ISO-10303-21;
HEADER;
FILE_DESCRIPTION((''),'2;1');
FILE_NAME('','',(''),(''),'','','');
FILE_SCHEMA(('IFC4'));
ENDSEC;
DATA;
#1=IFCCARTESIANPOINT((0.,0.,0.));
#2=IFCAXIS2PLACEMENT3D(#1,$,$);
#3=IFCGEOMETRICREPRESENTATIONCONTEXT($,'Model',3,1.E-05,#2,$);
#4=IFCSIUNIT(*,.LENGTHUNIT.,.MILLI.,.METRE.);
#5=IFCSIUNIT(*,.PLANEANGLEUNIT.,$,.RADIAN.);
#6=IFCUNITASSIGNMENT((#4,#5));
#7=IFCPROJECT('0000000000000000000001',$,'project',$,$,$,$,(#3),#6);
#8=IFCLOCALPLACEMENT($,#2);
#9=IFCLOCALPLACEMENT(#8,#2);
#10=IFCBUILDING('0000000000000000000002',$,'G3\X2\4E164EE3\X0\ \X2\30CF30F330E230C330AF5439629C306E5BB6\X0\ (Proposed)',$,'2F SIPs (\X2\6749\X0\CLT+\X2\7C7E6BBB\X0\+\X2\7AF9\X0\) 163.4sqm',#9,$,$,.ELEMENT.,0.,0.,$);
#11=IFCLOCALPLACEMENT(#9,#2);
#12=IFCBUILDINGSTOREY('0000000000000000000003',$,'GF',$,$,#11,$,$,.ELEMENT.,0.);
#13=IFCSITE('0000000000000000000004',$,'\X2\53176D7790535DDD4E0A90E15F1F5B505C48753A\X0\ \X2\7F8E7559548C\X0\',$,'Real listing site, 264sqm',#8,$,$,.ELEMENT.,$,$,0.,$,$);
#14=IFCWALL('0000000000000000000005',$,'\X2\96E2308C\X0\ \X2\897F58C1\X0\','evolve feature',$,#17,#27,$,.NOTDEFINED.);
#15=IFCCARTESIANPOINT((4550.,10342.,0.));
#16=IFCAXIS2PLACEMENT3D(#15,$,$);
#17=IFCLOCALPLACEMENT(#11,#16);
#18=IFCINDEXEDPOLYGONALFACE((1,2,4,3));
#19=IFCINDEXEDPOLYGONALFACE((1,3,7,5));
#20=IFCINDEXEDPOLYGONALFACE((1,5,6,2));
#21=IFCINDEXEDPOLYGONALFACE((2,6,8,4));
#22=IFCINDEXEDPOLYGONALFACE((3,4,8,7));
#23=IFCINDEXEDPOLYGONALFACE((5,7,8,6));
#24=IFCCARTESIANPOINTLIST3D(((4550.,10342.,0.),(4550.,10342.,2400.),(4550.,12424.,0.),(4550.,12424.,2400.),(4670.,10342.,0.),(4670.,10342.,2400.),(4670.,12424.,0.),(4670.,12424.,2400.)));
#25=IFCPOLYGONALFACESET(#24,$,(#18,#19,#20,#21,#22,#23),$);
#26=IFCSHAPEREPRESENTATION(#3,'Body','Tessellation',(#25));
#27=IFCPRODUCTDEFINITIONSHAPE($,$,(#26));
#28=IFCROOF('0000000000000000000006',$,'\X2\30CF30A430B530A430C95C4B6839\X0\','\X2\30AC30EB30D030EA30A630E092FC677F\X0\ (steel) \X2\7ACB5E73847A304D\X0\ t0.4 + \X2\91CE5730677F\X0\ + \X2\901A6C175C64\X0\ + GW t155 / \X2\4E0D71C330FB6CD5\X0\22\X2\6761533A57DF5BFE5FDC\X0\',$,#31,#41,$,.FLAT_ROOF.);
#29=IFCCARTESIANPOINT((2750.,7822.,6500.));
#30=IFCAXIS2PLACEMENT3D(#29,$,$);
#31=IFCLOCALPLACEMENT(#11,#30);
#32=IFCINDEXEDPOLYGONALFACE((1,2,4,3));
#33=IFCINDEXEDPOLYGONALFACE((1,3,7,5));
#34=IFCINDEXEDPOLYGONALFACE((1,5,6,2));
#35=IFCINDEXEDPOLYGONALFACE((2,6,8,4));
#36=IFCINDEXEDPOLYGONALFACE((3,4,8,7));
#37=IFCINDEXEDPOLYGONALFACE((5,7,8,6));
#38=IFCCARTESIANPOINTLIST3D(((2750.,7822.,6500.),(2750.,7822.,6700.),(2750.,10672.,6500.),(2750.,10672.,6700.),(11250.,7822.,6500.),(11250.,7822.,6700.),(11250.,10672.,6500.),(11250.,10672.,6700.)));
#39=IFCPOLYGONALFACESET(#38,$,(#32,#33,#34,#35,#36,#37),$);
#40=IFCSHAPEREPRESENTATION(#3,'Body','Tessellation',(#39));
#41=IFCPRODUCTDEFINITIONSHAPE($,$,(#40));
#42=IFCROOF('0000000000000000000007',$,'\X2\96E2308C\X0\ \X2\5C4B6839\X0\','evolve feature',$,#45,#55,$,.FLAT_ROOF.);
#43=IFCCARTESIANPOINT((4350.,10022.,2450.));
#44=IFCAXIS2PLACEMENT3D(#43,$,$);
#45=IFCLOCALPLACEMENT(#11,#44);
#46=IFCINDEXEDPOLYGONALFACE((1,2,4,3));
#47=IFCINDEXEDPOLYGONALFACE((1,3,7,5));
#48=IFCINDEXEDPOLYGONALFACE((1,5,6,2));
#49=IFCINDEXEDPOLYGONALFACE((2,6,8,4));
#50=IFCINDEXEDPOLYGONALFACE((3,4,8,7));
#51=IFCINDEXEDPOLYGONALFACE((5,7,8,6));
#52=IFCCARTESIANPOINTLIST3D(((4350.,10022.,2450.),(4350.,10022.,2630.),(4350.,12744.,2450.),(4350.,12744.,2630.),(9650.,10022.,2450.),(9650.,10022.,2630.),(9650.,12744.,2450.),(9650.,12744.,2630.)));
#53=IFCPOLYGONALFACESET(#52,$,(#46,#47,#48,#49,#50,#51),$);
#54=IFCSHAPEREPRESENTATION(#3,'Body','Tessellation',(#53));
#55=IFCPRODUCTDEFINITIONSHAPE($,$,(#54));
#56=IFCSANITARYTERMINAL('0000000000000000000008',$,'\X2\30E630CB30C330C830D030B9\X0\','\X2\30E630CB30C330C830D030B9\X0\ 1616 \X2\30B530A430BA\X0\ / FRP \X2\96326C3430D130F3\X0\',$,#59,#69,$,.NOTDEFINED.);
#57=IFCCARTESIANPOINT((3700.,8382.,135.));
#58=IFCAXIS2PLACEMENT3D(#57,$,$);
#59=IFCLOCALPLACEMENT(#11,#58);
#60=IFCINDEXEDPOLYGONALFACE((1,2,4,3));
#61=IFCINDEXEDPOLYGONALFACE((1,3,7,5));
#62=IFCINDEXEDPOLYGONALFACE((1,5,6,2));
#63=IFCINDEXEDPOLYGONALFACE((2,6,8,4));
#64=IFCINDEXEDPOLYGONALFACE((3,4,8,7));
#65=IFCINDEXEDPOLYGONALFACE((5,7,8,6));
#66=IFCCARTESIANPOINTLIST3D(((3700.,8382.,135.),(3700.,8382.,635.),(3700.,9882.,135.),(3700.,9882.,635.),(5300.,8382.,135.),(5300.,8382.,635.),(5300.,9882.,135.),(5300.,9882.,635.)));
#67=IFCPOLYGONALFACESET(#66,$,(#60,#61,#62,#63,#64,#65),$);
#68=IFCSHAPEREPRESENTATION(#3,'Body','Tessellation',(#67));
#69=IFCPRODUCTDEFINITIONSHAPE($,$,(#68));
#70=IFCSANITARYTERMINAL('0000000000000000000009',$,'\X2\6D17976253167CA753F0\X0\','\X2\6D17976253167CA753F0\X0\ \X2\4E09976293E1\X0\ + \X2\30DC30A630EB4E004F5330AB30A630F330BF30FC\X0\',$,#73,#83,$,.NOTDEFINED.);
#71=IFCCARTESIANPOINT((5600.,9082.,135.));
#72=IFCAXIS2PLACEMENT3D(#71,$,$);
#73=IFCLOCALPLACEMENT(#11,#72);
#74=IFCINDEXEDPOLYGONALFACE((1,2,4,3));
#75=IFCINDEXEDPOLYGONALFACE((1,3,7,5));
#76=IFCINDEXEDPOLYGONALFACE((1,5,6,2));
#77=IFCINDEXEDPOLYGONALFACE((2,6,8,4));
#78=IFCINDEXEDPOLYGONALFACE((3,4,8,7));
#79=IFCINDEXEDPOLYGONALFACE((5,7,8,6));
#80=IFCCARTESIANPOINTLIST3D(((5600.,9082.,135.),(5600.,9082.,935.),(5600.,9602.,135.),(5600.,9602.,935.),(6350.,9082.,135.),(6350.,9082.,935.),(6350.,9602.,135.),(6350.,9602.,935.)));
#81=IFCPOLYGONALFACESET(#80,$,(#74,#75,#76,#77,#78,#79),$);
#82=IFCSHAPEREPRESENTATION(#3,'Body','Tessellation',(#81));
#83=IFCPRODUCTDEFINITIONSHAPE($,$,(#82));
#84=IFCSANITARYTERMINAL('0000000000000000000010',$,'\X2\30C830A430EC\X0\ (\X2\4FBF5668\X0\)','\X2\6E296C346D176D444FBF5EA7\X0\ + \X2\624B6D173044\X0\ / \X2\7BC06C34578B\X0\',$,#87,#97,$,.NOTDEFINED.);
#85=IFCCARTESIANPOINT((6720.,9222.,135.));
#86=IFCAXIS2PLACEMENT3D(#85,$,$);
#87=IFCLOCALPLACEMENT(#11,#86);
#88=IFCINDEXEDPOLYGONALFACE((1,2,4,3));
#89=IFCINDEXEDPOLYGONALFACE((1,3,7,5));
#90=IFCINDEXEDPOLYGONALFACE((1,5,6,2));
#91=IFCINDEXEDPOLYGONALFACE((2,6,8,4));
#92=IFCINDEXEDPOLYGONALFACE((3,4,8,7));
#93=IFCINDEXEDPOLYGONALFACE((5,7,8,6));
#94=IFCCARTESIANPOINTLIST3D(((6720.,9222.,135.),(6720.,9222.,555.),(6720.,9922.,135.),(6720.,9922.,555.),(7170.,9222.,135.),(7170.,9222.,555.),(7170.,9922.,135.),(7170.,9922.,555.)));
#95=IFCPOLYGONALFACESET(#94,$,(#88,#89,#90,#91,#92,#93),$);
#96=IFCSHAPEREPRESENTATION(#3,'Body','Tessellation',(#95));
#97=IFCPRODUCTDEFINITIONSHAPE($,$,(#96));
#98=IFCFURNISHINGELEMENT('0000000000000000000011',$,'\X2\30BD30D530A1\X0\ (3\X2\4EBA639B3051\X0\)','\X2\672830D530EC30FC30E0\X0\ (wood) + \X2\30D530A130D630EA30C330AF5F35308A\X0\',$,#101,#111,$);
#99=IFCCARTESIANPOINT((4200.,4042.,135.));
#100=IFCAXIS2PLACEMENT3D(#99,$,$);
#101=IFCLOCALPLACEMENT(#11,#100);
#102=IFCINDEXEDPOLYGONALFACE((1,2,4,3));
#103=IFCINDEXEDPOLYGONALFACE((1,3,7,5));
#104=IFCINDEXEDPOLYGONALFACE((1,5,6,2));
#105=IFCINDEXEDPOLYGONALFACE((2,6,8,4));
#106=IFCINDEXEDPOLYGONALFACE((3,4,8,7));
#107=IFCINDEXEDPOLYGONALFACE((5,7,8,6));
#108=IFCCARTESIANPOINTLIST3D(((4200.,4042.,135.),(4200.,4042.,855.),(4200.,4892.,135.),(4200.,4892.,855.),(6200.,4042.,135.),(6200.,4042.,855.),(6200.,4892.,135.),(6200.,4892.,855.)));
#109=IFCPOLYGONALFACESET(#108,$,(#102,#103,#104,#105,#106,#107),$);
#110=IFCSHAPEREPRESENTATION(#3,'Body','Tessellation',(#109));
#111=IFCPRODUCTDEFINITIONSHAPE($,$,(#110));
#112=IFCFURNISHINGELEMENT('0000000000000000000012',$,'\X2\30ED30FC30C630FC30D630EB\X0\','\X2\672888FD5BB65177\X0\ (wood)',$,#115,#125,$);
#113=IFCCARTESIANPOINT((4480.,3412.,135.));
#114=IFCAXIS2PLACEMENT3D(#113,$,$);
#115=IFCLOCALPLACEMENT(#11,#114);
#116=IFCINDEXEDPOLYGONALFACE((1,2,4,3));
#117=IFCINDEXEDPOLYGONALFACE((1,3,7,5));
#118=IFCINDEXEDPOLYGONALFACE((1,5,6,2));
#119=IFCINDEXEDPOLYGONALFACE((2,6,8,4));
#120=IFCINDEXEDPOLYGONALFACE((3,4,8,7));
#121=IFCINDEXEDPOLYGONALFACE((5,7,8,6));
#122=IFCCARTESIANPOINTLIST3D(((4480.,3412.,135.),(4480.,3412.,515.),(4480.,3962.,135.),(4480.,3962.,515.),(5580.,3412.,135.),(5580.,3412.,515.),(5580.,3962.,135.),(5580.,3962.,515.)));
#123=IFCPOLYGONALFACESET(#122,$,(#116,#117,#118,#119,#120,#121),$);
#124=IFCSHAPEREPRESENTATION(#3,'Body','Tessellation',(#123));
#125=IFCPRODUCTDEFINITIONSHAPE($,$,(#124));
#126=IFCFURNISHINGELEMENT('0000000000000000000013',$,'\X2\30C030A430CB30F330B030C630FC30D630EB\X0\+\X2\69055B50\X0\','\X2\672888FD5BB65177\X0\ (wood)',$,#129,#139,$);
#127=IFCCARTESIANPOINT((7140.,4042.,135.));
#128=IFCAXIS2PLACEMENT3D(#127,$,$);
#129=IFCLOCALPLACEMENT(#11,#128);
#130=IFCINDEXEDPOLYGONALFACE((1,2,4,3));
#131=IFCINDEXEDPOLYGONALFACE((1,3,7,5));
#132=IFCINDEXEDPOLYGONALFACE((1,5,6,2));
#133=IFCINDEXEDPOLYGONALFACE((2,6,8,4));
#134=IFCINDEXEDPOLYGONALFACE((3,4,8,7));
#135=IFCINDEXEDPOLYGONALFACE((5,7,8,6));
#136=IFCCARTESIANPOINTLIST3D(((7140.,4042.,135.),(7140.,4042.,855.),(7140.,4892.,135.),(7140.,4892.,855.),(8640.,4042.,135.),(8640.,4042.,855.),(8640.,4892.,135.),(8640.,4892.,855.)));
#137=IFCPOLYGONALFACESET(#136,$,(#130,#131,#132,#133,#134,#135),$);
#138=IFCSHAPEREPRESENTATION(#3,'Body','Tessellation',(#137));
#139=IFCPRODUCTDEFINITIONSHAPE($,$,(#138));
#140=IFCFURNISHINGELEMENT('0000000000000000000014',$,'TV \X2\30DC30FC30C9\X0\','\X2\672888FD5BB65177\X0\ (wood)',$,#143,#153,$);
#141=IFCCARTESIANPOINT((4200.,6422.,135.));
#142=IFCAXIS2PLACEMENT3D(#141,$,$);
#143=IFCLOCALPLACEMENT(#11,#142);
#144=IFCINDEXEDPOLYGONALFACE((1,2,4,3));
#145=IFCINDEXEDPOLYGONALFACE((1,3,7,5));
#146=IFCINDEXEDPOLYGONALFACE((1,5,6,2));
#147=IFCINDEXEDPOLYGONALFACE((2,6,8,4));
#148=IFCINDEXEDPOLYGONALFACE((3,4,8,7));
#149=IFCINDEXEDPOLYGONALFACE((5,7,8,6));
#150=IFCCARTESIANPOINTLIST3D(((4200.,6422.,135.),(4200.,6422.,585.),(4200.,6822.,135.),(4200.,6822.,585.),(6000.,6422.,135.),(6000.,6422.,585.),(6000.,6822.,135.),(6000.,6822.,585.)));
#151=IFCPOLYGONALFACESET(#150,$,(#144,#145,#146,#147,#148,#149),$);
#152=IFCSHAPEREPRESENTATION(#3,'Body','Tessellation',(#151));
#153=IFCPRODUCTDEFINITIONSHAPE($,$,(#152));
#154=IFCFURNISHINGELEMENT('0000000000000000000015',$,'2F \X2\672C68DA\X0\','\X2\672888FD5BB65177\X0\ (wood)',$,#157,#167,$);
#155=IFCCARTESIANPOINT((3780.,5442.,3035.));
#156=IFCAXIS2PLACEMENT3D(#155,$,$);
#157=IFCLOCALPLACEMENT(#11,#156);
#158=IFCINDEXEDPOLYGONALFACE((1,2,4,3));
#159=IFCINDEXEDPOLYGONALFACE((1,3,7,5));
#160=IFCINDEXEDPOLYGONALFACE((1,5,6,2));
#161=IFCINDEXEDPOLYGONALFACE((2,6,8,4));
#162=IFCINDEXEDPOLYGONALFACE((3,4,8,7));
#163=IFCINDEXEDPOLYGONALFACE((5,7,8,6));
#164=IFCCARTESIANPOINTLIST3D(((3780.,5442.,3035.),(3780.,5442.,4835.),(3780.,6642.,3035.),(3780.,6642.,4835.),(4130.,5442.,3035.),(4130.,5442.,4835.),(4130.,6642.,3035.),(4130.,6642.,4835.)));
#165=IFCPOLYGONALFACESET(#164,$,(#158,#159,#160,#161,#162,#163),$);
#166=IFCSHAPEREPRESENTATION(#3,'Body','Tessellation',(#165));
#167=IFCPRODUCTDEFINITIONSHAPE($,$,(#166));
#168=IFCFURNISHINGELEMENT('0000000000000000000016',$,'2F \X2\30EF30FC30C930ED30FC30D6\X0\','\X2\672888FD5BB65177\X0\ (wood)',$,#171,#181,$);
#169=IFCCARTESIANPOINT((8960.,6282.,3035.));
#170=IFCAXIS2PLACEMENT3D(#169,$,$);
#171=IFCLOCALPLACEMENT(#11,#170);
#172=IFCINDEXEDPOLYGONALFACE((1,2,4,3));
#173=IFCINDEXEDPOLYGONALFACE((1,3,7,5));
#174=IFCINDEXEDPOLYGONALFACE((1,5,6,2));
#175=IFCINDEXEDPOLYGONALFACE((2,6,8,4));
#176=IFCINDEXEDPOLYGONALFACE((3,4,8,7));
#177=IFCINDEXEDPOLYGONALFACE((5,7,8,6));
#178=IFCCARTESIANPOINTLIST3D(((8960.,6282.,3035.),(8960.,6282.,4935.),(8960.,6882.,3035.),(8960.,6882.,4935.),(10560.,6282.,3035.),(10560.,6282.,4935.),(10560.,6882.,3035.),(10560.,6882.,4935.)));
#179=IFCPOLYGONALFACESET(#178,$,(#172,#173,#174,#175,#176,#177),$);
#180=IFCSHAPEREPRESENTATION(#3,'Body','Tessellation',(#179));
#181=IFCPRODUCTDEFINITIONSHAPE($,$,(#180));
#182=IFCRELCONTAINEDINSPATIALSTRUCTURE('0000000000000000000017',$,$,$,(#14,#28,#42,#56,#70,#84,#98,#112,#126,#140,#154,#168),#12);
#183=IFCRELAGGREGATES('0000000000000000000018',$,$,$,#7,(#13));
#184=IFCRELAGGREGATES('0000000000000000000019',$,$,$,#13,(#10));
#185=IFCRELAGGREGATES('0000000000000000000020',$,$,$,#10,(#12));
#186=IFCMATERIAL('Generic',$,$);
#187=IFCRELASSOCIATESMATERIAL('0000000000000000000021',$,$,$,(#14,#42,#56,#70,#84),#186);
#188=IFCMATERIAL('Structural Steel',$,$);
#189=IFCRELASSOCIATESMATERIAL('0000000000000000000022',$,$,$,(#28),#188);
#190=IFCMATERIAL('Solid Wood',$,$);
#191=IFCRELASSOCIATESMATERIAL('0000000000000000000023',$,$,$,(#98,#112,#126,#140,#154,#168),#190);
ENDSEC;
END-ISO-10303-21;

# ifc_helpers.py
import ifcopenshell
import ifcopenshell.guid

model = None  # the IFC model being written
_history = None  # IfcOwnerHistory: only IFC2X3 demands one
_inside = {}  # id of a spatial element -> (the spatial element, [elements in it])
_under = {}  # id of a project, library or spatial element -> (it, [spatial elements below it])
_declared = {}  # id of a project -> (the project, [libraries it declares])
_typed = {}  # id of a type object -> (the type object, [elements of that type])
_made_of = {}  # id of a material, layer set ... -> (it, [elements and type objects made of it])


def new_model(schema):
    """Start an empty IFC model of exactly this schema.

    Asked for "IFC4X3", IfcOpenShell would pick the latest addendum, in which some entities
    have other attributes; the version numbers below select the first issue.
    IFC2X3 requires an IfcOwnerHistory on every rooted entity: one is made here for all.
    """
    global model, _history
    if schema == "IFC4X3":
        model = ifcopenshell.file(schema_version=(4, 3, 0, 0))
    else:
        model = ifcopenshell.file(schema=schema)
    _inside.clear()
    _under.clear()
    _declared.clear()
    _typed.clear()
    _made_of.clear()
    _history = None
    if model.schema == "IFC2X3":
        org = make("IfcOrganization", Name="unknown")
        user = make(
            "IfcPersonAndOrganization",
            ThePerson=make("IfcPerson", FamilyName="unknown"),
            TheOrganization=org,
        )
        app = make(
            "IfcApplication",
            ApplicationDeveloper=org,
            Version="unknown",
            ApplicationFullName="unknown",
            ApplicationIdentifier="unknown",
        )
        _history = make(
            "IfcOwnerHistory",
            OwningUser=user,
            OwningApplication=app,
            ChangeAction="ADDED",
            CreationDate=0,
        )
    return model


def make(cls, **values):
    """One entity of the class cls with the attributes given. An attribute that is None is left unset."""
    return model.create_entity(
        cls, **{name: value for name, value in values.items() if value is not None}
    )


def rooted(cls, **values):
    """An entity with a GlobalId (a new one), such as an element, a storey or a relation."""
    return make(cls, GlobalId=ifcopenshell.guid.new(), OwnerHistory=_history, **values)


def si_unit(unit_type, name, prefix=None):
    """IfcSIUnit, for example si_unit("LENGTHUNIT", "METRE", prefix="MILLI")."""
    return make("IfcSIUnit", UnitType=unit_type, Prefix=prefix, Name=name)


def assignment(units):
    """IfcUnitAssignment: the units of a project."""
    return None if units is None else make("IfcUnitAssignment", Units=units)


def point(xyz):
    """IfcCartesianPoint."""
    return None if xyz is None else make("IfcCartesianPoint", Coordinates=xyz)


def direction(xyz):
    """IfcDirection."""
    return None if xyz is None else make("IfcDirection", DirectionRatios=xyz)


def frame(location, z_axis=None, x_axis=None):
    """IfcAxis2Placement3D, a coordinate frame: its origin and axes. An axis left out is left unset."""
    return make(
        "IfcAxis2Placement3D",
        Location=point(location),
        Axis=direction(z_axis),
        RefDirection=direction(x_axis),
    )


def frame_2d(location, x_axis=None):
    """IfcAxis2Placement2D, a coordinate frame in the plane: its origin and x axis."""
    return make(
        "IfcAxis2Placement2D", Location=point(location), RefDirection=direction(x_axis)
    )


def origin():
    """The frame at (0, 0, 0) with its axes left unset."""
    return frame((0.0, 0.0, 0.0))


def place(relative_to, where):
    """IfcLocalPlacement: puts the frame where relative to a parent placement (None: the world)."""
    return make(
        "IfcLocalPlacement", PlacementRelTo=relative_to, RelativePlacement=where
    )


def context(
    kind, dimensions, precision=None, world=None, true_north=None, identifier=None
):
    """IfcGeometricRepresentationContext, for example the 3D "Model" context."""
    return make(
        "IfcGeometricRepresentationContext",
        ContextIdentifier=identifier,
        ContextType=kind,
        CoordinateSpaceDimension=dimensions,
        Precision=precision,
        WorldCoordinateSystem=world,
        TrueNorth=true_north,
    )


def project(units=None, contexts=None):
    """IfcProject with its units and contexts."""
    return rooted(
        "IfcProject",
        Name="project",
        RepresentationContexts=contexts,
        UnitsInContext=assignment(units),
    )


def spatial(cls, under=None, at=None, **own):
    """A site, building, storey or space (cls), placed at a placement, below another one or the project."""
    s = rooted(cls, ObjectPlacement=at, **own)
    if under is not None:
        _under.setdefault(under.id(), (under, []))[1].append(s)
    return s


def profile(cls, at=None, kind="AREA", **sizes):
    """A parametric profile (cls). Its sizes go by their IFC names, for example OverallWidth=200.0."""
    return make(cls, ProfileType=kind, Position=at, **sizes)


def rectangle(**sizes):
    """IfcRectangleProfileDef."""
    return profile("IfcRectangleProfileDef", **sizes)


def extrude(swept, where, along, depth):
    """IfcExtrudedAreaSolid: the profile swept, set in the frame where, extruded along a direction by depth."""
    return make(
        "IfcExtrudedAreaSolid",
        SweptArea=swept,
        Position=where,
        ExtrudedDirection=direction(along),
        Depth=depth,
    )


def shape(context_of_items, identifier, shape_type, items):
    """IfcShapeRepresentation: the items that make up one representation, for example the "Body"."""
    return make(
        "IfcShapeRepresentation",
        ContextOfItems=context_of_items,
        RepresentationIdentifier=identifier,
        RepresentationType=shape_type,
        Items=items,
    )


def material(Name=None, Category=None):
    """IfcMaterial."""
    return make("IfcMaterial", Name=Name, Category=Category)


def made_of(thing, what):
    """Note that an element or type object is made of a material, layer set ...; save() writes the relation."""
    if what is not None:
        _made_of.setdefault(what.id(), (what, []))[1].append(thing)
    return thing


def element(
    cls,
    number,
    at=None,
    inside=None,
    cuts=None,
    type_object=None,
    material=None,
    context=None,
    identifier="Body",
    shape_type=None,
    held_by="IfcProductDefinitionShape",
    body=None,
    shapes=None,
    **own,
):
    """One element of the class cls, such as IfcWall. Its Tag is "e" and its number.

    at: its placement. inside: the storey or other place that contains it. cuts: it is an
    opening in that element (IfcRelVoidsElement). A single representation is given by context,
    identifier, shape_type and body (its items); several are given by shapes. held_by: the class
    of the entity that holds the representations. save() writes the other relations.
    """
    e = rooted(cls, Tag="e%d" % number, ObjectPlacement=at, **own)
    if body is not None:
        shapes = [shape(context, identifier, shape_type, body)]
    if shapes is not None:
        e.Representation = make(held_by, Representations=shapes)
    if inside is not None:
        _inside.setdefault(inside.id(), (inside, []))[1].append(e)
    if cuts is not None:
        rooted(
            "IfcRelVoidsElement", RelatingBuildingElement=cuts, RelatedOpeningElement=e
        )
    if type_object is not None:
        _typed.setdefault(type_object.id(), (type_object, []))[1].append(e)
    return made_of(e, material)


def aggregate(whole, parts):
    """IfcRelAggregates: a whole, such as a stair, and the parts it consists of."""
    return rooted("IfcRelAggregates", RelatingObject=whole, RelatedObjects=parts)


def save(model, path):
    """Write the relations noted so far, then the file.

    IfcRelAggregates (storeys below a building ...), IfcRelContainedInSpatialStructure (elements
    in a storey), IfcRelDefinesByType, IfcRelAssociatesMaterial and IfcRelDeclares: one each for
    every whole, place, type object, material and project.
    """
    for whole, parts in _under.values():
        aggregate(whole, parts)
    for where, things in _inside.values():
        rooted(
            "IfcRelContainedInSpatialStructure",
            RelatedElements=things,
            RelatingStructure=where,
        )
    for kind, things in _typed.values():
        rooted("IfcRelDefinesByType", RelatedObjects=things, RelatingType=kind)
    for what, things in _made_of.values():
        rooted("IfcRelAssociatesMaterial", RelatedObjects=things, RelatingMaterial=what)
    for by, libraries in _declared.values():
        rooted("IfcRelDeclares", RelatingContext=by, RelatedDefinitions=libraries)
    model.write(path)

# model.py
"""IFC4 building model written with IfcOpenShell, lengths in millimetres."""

from ifc_helpers import new_model, si_unit, frame, frame_2d, origin, place, context, project, spatial, rectangle, extrude, material, element, save


model = new_model("IFC4")

# Units and contexts
model_context = context("Model", 3, precision=1e-05, world=origin())
ifc_project = project(units=[si_unit("LENGTHUNIT", "METRE", prefix="MILLI"), si_unit("PLANEANGLEUNIT", "RADIAN")], contexts=[model_context])

# Site, building, storey
site_placement = place(None, origin())
site = spatial("IfcSite", under=ifc_project, at=site_placement, Name="北海道川上郡弟子屈町 美留和", ObjectType="Real listing site, 264sqm", CompositionType="ELEMENT", RefElevation=0.0)
building_placement = place(site_placement, origin())
building = spatial("IfcBuilding", under=site, at=building_placement, Name="G3世代 ハンモック吹抜の家 (Proposed)", ObjectType="2F SIPs (杉CLT+籾殻+竹) 163.4sqm", CompositionType="ELEMENT", ElevationOfRefHeight=0.0, ElevationOfTerrain=0.0)
storey_placement = place(building_placement, origin())
storey = spatial("IfcBuildingStorey", under=building, at=storey_placement, Name="GF", CompositionType="ELEMENT", Elevation=0.0)

# Shared definitions
ifc_material_1 = material(Name="Generic")

# Shared definitions
ifc_material_2 = material(Name="Solid Wood")

# Wall
wall_1_placement = place(storey_placement, frame((4550.0, 10342.0, 0.0)))
element("IfcWall", 1, at=wall_1_placement, inside=storey, material=ifc_material_1, Name="離れ 西壁", Description="evolve feature", PredefinedType="NOTDEFINED", context=model_context, shape_type="SweptSolid", body=[
    extrude(rectangle(XDim=120.0, YDim=2082.0, at=frame_2d((60.0, 1041.0))), frame((4550.0, 10342.0, 0.0)), (0.0, 0.0, 1.0), 2400.0),
])

# Roofs
ifc_material_3 = material(Name="Structural Steel")
roof_1_placement = place(storey_placement, frame((2750.0, 7822.0, 6500.0)))
element("IfcRoof", 2, at=roof_1_placement, inside=storey, material=ifc_material_3, Name="ハイサイド屋根", Description="ガルバリウム鋼板 (steel) 立平葺き t0.4 + 野地板 + 通気層 + GW t155 / 不燃・法22条区域対応", PredefinedType="FLAT_ROOF", context=model_context, shape_type="SweptSolid", body=[
    extrude(rectangle(XDim=8500.0, YDim=2850.0, at=frame_2d((4250.0, 1425.0))), frame((2750.0, 7822.0, 6500.0)), (0.0, 0.0, 1.0), 200.0),
])
roof_2_placement = place(storey_placement, frame((4350.0, 10022.0, 2450.0)))
element("IfcRoof", 3, at=roof_2_placement, inside=storey, material=ifc_material_1, Name="離れ 屋根", Description="evolve feature", PredefinedType="FLAT_ROOF", context=model_context, shape_type="SweptSolid", body=[
    extrude(rectangle(XDim=5300.0, YDim=2722.0, at=frame_2d((2650.0, 1361.0))), frame((4350.0, 10022.0, 2450.0)), (0.0, 0.0, 1.0), 180.0),
])

# Sanitary terminals
sanitary_terminal_1_placement = place(storey_placement, frame((3700.0, 8382.0, 135.0)))
element("IfcSanitaryTerminal", 4, at=sanitary_terminal_1_placement, inside=storey, material=ifc_material_1, Name="ユニットバス", Description="ユニットバス 1616 サイズ / FRP 防水パン", PredefinedType="NOTDEFINED", context=model_context, shape_type="SweptSolid", body=[
    extrude(rectangle(XDim=1600.0, YDim=1500.0, at=frame_2d((800.0, 750.0))), frame((3700.0, 8382.0, 135.0)), (0.0, 0.0, 1.0), 500.0),
])
sanitary_terminal_2_placement = place(storey_placement, frame((5600.0, 9082.0, 135.0)))
element("IfcSanitaryTerminal", 5, at=sanitary_terminal_2_placement, inside=storey, material=ifc_material_1, Name="洗面化粧台", Description="洗面化粧台 三面鏡 + ボウル一体カウンター", PredefinedType="NOTDEFINED", context=model_context, shape_type="SweptSolid", body=[
    extrude(rectangle(XDim=750.0, YDim=520.0, at=frame_2d((375.0, 260.0))), frame((5600.0, 9082.0, 135.0)), (0.0, 0.0, 1.0), 800.0),
])
sanitary_terminal_3_placement = place(storey_placement, frame((6720.0, 9222.0, 135.0)))
element("IfcSanitaryTerminal", 6, at=sanitary_terminal_3_placement, inside=storey, material=ifc_material_1, Name="トイレ (便器)", Description="温水洗浄便座 + 手洗い / 節水型", PredefinedType="NOTDEFINED", context=model_context, shape_type="SweptSolid", body=[
    extrude(rectangle(XDim=450.0, YDim=700.0, at=frame_2d((225.0, 350.0))), frame((6720.0, 9222.0, 135.0)), (0.0, 0.0, 1.0), 420.0),
])

# Furnishing elements
furnishing_1_placement = place(storey_placement, frame((4200.0, 4042.0, 135.0)))
element("IfcFurnishingElement", 7, at=furnishing_1_placement, inside=storey, material=ifc_material_2, Name="ソファ (3人掛け)", Description="木フレーム (wood) + ファブリック張り", context=model_context, shape_type="SweptSolid", body=[
    extrude(rectangle(XDim=2000.0, YDim=850.0, at=frame_2d((1000.0, 425.0))), frame((4200.0, 4042.0, 135.0)), (0.0, 0.0, 1.0), 720.0),
])
furnishing_2_placement = place(storey_placement, frame((4480.0, 3412.0, 135.0)))
element("IfcFurnishingElement", 8, at=furnishing_2_placement, inside=storey, material=ifc_material_2, Name="ローテーブル", Description="木製家具 (wood)", context=model_context, shape_type="SweptSolid", body=[
    extrude(rectangle(XDim=1100.0, YDim=550.0, at=frame_2d((550.0, 275.0))), frame((4480.0, 3412.0, 135.0)), (0.0, 0.0, 1.0), 380.0),
])
furnishing_3_placement = place(storey_placement, frame((7140.0, 4042.0, 135.0)))
element("IfcFurnishingElement", 9, at=furnishing_3_placement, inside=storey, material=ifc_material_2, Name="ダイニングテーブル+椅子", Description="木製家具 (wood)", context=model_context, shape_type="SweptSolid", body=[
    extrude(rectangle(XDim=1500.0, YDim=850.0, at=frame_2d((750.0, 425.0))), frame((7140.0, 4042.0, 135.0)), (0.0, 0.0, 1.0), 720.0),
])
furnishing_4_placement = place(storey_placement, frame((4200.0, 6422.0, 135.0)))
element("IfcFurnishingElement", 10, at=furnishing_4_placement, inside=storey, material=ifc_material_2, Name="TV ボード", Description="木製家具 (wood)", context=model_context, shape_type="SweptSolid", body=[
    extrude(rectangle(XDim=1800.0, YDim=400.0, at=frame_2d((900.0, 200.0))), frame((4200.0, 6422.0, 135.0)), (0.0, 0.0, 1.0), 450.0),
])
furnishing_5_placement = place(storey_placement, frame((3780.0, 5442.0, 3035.0)))
element("IfcFurnishingElement", 11, at=furnishing_5_placement, inside=storey, material=ifc_material_2, Name="2F 本棚", Description="木製家具 (wood)", context=model_context, shape_type="SweptSolid", body=[
    extrude(rectangle(XDim=350.0, YDim=1200.0, at=frame_2d((175.0, 600.0))), frame((3780.0, 5442.0, 3035.0)), (0.0, 0.0, 1.0), 1800.0),
])
furnishing_6_placement = place(storey_placement, frame((8960.0, 6282.0, 3035.0)))
element("IfcFurnishingElement", 12, at=furnishing_6_placement, inside=storey, material=ifc_material_2, Name="2F ワードローブ", Description="木製家具 (wood)", context=model_context, shape_type="SweptSolid", body=[
    extrude(rectangle(XDim=1600.0, YDim=600.0, at=frame_2d((800.0, 300.0))), frame((8960.0, 6282.0, 3035.0)), (0.0, 0.0, 1.0), 1900.0),
])

save(model, "model.ifc")
